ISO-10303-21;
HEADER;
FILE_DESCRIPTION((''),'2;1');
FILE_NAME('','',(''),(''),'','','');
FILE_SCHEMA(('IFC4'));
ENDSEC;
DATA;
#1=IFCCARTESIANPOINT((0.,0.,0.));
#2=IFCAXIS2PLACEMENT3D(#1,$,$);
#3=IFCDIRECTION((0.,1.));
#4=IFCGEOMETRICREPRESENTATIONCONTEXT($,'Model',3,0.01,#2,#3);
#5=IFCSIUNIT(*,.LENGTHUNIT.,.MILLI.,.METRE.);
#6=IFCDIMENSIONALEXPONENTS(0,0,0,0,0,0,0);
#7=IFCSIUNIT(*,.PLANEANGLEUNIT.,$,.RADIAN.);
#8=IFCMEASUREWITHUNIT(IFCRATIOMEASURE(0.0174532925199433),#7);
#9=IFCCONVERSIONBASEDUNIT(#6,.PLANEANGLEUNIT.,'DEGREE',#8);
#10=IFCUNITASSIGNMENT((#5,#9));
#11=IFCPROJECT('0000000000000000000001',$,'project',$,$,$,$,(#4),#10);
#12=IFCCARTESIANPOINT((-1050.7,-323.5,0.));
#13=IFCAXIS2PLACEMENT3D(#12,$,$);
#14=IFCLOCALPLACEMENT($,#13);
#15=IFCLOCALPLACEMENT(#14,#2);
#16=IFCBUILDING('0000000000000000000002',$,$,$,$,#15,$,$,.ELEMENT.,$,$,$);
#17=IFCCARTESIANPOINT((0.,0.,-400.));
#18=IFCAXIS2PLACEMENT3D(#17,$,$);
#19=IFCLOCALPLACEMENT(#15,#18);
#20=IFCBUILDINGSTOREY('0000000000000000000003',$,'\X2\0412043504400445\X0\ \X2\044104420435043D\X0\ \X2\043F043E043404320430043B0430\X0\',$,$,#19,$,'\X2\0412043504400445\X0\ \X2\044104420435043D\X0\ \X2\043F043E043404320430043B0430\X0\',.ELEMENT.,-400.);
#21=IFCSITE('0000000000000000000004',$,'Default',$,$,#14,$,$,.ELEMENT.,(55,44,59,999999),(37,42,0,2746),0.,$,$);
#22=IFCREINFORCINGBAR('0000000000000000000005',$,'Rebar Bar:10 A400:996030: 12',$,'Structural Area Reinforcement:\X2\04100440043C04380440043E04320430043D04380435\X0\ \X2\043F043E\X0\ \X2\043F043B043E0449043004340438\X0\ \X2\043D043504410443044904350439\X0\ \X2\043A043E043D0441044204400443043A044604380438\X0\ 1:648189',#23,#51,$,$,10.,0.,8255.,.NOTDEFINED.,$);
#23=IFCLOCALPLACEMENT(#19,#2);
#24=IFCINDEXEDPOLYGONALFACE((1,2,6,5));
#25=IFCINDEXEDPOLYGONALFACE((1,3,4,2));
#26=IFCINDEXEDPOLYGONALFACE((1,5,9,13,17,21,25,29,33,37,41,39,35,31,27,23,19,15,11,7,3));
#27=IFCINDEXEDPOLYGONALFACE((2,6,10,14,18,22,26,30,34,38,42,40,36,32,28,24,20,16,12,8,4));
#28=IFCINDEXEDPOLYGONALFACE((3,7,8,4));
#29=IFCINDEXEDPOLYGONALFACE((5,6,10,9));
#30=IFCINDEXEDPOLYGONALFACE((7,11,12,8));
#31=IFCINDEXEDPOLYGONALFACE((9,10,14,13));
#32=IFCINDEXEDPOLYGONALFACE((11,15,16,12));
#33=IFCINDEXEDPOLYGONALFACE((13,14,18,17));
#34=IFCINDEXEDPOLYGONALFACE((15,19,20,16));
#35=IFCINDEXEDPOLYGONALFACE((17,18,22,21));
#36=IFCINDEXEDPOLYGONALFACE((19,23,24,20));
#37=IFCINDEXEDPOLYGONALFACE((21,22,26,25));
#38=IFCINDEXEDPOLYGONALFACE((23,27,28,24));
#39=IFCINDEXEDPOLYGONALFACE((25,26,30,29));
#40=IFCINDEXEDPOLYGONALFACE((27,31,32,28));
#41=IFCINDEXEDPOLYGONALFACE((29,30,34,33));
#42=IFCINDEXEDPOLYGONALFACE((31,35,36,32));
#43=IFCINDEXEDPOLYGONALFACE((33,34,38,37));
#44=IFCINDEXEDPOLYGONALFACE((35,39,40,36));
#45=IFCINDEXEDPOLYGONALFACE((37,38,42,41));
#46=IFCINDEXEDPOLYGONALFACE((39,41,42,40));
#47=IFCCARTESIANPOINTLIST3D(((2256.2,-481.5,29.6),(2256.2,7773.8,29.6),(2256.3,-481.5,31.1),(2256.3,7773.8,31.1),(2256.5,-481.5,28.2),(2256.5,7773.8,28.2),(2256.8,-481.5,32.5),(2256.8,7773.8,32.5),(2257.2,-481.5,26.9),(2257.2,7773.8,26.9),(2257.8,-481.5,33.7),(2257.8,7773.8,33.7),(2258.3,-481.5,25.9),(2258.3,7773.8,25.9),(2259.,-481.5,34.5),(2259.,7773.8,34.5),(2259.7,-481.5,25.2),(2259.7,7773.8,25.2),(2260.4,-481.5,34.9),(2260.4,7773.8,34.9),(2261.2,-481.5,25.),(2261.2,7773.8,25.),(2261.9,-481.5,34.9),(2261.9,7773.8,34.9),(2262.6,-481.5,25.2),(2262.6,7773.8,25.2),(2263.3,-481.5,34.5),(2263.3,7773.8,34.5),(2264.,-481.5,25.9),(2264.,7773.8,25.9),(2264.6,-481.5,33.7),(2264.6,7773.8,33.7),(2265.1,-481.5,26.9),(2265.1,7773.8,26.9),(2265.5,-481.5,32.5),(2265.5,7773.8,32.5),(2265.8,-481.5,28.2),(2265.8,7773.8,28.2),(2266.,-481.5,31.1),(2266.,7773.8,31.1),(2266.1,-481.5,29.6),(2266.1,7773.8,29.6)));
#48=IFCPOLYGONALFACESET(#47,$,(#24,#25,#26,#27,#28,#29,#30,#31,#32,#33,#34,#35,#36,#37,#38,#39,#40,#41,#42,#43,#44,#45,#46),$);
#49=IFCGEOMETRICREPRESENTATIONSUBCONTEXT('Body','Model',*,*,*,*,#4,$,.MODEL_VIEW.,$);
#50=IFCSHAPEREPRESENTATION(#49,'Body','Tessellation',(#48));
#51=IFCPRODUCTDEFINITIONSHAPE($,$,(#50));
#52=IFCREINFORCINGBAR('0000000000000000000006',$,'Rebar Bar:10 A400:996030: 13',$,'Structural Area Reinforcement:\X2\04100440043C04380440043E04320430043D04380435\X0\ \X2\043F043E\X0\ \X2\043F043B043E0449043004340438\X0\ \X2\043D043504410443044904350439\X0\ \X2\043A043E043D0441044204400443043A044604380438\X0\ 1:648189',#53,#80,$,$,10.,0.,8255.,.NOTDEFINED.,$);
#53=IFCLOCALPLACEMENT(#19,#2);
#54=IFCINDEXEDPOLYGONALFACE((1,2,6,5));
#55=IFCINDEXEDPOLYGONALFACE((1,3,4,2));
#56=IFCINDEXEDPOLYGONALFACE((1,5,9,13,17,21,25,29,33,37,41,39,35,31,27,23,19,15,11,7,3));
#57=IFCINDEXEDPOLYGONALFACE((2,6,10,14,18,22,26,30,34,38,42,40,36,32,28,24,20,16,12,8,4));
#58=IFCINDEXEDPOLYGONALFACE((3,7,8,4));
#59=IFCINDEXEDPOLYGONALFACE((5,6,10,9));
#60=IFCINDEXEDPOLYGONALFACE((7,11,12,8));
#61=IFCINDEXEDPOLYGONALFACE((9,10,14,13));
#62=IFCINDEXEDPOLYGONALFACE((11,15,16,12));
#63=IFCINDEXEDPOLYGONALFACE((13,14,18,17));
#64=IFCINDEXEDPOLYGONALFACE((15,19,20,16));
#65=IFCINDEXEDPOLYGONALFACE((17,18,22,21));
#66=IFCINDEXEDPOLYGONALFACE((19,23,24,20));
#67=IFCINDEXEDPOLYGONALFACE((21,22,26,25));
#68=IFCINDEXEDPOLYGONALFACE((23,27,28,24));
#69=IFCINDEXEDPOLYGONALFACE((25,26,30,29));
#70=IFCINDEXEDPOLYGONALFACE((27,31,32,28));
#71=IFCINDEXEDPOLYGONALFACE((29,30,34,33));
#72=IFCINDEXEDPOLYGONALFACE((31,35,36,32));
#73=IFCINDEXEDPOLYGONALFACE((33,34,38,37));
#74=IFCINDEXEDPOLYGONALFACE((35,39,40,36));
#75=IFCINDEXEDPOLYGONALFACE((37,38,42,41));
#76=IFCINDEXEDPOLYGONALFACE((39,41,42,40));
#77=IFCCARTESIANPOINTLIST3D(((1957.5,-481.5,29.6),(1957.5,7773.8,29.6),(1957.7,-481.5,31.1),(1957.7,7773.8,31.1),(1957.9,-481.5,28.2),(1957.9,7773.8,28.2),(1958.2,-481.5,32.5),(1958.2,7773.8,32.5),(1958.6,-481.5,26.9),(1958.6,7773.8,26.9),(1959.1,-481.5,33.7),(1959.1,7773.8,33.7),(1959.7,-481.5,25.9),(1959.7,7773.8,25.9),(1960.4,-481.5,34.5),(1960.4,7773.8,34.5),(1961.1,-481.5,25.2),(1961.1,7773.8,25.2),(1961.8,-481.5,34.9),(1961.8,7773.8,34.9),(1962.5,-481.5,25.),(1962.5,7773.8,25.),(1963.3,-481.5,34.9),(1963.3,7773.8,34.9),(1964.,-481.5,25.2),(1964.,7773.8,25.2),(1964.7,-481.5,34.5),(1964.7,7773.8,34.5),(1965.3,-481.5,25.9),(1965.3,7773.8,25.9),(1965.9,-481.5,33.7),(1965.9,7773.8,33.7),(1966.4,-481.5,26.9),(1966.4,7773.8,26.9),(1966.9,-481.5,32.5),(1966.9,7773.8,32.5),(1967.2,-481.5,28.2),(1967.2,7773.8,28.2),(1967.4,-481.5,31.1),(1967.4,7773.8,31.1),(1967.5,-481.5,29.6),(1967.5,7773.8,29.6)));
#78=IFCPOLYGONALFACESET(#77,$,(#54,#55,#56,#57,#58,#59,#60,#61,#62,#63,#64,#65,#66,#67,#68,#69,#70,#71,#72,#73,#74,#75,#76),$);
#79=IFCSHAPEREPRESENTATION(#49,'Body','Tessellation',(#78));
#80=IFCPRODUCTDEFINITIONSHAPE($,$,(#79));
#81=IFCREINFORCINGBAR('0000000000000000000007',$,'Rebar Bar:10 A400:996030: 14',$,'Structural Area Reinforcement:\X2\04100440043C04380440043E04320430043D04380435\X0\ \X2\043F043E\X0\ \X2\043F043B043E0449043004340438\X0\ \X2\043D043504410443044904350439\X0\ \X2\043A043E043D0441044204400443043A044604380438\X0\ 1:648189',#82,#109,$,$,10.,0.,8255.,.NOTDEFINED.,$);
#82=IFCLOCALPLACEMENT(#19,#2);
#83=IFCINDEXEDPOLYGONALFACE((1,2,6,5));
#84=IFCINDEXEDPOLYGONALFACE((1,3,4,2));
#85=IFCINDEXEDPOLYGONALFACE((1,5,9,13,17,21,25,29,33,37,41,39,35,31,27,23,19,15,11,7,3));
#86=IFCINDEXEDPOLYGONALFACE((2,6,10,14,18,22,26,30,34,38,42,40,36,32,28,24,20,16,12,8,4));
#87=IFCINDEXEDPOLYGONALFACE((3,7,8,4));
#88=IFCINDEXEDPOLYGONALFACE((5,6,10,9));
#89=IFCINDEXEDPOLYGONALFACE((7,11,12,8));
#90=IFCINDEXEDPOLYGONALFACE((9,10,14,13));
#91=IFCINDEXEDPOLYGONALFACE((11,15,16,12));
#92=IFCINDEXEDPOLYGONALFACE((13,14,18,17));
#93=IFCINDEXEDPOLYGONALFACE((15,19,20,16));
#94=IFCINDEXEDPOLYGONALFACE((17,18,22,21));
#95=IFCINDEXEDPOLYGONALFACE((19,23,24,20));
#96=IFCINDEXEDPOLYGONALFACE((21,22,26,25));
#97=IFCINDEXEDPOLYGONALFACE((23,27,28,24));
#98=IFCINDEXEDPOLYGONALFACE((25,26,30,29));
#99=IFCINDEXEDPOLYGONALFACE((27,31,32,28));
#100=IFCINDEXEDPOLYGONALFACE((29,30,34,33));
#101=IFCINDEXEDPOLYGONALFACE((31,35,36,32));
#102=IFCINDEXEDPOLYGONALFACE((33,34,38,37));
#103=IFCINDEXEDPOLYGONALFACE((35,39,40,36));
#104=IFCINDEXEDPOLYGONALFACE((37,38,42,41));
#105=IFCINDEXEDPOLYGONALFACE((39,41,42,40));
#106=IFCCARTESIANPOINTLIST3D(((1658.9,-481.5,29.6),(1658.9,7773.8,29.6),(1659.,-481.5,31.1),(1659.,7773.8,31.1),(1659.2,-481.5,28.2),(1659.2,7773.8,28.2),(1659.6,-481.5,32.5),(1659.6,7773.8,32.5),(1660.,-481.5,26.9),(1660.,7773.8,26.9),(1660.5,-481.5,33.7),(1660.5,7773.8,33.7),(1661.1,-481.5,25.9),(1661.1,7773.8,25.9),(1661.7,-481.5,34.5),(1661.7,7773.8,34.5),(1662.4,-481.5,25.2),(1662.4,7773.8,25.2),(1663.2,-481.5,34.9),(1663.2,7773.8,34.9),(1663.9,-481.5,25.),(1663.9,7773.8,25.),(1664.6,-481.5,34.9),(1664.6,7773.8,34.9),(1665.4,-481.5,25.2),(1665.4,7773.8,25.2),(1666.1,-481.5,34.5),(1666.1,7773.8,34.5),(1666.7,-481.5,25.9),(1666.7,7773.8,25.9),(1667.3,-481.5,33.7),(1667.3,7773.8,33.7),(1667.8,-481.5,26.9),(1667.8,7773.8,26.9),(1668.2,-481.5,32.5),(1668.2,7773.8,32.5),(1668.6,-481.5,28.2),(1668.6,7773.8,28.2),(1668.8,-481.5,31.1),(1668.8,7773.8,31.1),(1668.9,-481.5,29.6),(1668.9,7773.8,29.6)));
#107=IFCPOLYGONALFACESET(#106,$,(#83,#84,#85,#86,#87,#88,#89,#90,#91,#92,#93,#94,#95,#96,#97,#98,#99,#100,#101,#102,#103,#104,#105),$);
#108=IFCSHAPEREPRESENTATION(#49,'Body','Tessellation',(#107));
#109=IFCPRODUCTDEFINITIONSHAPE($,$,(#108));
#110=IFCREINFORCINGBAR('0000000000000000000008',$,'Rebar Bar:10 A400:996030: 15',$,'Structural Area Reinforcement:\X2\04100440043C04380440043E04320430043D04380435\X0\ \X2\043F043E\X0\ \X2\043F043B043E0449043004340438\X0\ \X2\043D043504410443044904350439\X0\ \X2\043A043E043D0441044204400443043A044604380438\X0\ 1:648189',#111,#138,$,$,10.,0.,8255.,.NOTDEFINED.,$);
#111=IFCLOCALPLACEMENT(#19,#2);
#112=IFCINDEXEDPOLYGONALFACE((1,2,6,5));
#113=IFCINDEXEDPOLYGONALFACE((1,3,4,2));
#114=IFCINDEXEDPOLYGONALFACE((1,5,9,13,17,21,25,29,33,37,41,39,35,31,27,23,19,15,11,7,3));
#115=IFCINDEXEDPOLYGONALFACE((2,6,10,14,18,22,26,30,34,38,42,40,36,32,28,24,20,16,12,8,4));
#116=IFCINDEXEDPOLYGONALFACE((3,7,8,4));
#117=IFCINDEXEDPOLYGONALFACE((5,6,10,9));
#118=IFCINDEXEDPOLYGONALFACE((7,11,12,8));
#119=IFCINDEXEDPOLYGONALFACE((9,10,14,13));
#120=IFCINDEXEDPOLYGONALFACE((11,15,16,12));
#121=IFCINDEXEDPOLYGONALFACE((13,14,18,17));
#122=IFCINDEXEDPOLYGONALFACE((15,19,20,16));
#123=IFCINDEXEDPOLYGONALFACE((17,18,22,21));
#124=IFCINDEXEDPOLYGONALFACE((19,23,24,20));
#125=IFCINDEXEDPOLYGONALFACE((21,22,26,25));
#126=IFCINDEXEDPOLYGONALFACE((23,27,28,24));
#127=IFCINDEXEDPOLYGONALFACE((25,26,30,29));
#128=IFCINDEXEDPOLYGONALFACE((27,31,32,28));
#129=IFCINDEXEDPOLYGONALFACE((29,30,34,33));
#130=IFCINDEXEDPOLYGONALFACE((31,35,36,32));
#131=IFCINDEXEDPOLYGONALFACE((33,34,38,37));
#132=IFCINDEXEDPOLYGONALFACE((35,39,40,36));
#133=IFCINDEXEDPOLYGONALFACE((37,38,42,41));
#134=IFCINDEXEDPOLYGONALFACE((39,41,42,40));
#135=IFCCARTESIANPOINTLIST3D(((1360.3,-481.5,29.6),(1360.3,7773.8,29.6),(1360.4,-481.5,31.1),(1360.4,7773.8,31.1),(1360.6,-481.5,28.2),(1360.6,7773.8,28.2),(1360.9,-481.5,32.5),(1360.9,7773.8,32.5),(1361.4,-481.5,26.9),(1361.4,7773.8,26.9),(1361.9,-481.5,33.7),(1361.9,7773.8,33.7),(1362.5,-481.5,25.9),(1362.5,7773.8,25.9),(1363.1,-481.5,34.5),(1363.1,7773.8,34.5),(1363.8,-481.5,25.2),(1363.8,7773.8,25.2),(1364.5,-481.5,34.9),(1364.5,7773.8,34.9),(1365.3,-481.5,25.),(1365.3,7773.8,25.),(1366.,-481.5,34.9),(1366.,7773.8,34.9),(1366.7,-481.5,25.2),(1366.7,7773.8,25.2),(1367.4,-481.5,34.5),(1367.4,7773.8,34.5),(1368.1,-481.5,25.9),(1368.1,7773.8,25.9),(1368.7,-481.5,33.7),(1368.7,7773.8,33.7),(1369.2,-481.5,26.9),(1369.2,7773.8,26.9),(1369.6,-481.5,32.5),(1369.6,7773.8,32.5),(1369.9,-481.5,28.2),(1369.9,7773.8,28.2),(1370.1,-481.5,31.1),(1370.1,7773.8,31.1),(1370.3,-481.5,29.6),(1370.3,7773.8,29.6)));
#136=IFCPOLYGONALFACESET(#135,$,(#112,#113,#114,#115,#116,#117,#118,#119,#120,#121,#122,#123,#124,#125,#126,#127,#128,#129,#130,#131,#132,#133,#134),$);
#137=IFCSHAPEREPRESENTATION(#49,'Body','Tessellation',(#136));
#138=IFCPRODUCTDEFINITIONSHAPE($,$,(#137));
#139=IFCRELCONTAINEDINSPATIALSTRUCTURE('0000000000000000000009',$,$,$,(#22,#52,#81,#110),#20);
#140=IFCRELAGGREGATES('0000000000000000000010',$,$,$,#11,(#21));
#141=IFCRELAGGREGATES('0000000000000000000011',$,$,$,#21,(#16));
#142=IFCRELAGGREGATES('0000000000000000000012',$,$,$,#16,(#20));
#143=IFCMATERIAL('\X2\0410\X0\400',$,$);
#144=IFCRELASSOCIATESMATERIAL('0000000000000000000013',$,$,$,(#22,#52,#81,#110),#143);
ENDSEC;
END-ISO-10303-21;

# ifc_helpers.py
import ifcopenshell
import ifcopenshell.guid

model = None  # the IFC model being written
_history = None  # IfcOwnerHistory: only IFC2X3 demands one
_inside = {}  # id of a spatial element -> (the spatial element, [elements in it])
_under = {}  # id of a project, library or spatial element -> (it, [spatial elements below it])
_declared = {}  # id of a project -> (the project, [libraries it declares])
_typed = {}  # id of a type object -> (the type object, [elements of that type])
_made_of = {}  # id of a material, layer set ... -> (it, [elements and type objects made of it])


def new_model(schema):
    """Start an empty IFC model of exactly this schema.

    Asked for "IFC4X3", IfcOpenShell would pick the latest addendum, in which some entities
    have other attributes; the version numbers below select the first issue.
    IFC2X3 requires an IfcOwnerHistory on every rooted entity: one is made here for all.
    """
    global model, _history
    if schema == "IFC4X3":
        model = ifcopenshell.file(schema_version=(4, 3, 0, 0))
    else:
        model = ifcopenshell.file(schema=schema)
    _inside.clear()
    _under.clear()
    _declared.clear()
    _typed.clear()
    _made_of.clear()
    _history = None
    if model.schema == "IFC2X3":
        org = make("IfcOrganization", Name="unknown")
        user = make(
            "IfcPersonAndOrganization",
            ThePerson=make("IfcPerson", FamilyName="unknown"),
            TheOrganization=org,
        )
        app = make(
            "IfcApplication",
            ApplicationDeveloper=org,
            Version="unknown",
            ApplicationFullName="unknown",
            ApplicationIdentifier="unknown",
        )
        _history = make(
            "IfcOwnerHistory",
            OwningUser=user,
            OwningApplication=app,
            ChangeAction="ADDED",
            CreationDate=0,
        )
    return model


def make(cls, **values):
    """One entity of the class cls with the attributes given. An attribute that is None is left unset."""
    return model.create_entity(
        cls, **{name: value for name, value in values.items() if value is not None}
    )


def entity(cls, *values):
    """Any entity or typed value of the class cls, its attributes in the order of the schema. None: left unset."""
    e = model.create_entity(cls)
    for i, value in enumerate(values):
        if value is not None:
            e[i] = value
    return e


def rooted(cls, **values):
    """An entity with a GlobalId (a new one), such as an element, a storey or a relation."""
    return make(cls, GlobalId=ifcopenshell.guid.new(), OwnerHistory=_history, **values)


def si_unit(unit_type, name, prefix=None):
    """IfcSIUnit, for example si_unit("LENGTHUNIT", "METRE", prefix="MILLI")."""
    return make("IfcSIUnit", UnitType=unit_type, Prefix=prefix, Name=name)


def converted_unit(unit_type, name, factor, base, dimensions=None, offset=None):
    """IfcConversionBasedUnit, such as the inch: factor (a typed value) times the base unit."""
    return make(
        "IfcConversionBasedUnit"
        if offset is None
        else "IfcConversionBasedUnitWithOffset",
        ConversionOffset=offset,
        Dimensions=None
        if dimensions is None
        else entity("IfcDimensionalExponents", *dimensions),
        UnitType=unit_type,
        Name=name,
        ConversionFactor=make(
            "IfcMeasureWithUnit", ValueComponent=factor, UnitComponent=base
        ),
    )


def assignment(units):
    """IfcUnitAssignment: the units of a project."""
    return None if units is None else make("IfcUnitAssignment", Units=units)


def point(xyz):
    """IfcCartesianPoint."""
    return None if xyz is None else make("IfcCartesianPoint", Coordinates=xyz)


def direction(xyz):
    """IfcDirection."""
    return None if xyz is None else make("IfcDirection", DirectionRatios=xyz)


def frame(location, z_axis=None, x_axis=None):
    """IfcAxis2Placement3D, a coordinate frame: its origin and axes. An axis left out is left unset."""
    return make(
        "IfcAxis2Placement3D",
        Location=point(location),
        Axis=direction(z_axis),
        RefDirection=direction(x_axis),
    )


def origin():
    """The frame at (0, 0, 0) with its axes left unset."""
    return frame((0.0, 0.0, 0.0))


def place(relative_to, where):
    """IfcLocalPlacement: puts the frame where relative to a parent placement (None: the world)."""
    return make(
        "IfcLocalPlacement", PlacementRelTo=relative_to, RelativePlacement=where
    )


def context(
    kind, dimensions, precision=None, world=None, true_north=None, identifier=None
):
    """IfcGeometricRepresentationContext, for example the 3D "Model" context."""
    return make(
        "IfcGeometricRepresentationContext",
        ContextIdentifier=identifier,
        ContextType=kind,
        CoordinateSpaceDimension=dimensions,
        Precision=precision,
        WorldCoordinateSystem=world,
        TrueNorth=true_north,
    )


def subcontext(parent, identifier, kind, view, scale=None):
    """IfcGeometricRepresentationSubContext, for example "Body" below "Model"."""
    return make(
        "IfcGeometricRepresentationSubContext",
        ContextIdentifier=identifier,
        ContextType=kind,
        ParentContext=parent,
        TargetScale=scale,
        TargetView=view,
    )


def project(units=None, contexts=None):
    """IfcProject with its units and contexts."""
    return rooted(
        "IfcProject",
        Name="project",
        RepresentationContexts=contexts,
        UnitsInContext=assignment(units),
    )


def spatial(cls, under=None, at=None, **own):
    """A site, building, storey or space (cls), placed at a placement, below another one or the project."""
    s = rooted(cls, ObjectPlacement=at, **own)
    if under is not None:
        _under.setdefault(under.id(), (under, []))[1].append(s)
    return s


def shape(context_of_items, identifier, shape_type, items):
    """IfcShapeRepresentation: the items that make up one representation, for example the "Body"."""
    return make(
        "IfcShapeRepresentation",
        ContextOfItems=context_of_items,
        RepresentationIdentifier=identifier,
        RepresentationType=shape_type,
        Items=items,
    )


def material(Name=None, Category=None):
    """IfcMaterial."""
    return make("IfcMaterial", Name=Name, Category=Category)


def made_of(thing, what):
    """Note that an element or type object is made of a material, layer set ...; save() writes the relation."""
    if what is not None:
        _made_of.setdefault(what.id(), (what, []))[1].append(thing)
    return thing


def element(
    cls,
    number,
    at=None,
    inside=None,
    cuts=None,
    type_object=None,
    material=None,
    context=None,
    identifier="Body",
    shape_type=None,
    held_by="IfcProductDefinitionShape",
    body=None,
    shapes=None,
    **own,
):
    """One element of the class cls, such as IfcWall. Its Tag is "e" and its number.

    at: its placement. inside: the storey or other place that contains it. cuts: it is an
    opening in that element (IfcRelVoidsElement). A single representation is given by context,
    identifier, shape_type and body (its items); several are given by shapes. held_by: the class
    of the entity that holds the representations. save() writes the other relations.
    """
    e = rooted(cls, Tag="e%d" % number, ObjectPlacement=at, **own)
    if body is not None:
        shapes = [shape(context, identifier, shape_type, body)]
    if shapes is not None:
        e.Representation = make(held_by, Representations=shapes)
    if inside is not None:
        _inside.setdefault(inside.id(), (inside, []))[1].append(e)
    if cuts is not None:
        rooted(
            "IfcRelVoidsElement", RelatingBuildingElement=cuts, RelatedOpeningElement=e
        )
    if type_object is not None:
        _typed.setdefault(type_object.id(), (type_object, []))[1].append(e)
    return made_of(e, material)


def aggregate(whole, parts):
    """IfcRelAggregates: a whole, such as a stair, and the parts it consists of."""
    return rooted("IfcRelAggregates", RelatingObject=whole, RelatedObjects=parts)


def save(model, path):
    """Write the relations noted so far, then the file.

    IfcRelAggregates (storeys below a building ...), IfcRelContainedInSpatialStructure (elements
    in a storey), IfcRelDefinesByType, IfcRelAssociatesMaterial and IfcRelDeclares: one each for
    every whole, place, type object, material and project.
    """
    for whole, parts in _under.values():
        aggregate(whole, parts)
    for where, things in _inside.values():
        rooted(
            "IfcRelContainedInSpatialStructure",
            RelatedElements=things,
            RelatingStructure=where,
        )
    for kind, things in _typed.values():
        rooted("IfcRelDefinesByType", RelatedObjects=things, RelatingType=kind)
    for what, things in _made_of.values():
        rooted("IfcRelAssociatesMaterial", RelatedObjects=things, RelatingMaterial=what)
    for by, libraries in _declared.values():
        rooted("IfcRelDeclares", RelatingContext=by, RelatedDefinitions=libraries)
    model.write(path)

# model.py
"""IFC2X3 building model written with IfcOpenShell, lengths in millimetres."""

from ifc_helpers import new_model, entity, si_unit, converted_unit, direction, frame, origin, place, context, subcontext, project, spatial, material, element, save


model = new_model("IFC2X3")

# Units and contexts
model_context = context("Model", 3, precision=0.01, world=origin(), true_north=direction((0.0, 1.0)))
body_context = subcontext(model_context, "Body", "Model", "MODEL_VIEW")
ifc_project = project(units=[si_unit("LENGTHUNIT", "METRE", prefix="MILLI"), converted_unit("PLANEANGLEUNIT", "DEGREE", entity("IfcRatioMeasure", 0.0174532925199433), si_unit("PLANEANGLEUNIT", "RADIAN"), dimensions=[0, 0, 0, 0, 0, 0, 0])], contexts=[model_context])

# Site, building, storey
site_placement = place(None, frame((-1050.7, -323.5, 0.0)))
site = spatial("IfcSite", under=ifc_project, at=site_placement, Name="Default", CompositionType="ELEMENT", RefLatitude=(55, 44, 59, 999999), RefLongitude=(37, 42, 0, 2746), RefElevation=0.0)
building_placement = place(site_placement, origin())
building = spatial("IfcBuilding", under=site, at=building_placement, CompositionType="ELEMENT")
storey_placement = place(building_placement, frame((0.0, 0.0, -400.0)))
storey = spatial("IfcBuildingStorey", under=building, at=storey_placement, Name="Верх стен подвала", LongName="Верх стен подвала", CompositionType="ELEMENT", Elevation=-400.0)

# Reinforcing bars
ifc_material = material(Name="А400")
reinforcing_bar_1_placement = place(storey_placement, origin())
element("IfcReinforcingBar", 1, at=reinforcing_bar_1_placement, inside=storey, material=ifc_material, Name="Rebar Bar:10 A400:996030: 12", ObjectType="Structural Area Reinforcement:Армирование по площади несущей конструкции 1:648189", BarLength=8255.0, BarRole="NOTDEFINED", CrossSectionArea=0.0, NominalDiameter=10.0, context=body_context, shape_type="AdvancedSweptSolid", body=[
    entity("IfcSweptDiskSolid", entity("IfcCompositeCurve", [entity("IfcCompositeCurveSegment", "CONTINUOUS", True, entity("IfcPolyline", [entity("IfcCartesianPoint", [2261.2, 7773.8, 30.0]), entity("IfcCartesianPoint", [2261.2, -481.5, 30.0])]))], False), 5.0, None, 0.0, 1.0),
])
reinforcing_bar_2_placement = place(storey_placement, origin())
element("IfcReinforcingBar", 2, at=reinforcing_bar_2_placement, inside=storey, material=ifc_material, Name="Rebar Bar:10 A400:996030: 13", ObjectType="Structural Area Reinforcement:Армирование по площади несущей конструкции 1:648189", BarLength=8255.0, BarRole="NOTDEFINED", CrossSectionArea=0.0, NominalDiameter=10.0, context=body_context, shape_type="AdvancedSweptSolid", body=[
    entity("IfcSweptDiskSolid", entity("IfcCompositeCurve", [entity("IfcCompositeCurveSegment", "CONTINUOUS", True, entity("IfcPolyline", [entity("IfcCartesianPoint", [1962.5, 7773.8, 30.0]), entity("IfcCartesianPoint", [1962.5, -481.5, 30.0])]))], False), 5.0, None, 0.0, 1.0),
])
reinforcing_bar_3_placement = place(storey_placement, origin())
element("IfcReinforcingBar", 3, at=reinforcing_bar_3_placement, inside=storey, material=ifc_material, Name="Rebar Bar:10 A400:996030: 14", ObjectType="Structural Area Reinforcement:Армирование по площади несущей конструкции 1:648189", BarLength=8255.0, BarRole="NOTDEFINED", CrossSectionArea=0.0, NominalDiameter=10.0, context=body_context, shape_type="AdvancedSweptSolid", body=[
    entity("IfcSweptDiskSolid", entity("IfcCompositeCurve", [entity("IfcCompositeCurveSegment", "CONTINUOUS", True, entity("IfcPolyline", [entity("IfcCartesianPoint", [1663.9, 7773.8, 30.0]), entity("IfcCartesianPoint", [1663.9, -481.5, 30.0])]))], False), 5.0, None, 0.0, 1.0),
])
reinforcing_bar_4_placement = place(storey_placement, origin())
element("IfcReinforcingBar", 4, at=reinforcing_bar_4_placement, inside=storey, material=ifc_material, Name="Rebar Bar:10 A400:996030: 15", ObjectType="Structural Area Reinforcement:Армирование по площади несущей конструкции 1:648189", BarLength=8255.0, BarRole="NOTDEFINED", CrossSectionArea=0.0, NominalDiameter=10.0, context=body_context, shape_type="AdvancedSweptSolid", body=[
    entity("IfcSweptDiskSolid", entity("IfcCompositeCurve", [entity("IfcCompositeCurveSegment", "CONTINUOUS", True, entity("IfcPolyline", [entity("IfcCartesianPoint", [1365.3, 7773.8, 30.0]), entity("IfcCartesianPoint", [1365.3, -481.5, 30.0])]))], False), 5.0, None, 0.0, 1.0),
])

save(model, "model.ifc")
